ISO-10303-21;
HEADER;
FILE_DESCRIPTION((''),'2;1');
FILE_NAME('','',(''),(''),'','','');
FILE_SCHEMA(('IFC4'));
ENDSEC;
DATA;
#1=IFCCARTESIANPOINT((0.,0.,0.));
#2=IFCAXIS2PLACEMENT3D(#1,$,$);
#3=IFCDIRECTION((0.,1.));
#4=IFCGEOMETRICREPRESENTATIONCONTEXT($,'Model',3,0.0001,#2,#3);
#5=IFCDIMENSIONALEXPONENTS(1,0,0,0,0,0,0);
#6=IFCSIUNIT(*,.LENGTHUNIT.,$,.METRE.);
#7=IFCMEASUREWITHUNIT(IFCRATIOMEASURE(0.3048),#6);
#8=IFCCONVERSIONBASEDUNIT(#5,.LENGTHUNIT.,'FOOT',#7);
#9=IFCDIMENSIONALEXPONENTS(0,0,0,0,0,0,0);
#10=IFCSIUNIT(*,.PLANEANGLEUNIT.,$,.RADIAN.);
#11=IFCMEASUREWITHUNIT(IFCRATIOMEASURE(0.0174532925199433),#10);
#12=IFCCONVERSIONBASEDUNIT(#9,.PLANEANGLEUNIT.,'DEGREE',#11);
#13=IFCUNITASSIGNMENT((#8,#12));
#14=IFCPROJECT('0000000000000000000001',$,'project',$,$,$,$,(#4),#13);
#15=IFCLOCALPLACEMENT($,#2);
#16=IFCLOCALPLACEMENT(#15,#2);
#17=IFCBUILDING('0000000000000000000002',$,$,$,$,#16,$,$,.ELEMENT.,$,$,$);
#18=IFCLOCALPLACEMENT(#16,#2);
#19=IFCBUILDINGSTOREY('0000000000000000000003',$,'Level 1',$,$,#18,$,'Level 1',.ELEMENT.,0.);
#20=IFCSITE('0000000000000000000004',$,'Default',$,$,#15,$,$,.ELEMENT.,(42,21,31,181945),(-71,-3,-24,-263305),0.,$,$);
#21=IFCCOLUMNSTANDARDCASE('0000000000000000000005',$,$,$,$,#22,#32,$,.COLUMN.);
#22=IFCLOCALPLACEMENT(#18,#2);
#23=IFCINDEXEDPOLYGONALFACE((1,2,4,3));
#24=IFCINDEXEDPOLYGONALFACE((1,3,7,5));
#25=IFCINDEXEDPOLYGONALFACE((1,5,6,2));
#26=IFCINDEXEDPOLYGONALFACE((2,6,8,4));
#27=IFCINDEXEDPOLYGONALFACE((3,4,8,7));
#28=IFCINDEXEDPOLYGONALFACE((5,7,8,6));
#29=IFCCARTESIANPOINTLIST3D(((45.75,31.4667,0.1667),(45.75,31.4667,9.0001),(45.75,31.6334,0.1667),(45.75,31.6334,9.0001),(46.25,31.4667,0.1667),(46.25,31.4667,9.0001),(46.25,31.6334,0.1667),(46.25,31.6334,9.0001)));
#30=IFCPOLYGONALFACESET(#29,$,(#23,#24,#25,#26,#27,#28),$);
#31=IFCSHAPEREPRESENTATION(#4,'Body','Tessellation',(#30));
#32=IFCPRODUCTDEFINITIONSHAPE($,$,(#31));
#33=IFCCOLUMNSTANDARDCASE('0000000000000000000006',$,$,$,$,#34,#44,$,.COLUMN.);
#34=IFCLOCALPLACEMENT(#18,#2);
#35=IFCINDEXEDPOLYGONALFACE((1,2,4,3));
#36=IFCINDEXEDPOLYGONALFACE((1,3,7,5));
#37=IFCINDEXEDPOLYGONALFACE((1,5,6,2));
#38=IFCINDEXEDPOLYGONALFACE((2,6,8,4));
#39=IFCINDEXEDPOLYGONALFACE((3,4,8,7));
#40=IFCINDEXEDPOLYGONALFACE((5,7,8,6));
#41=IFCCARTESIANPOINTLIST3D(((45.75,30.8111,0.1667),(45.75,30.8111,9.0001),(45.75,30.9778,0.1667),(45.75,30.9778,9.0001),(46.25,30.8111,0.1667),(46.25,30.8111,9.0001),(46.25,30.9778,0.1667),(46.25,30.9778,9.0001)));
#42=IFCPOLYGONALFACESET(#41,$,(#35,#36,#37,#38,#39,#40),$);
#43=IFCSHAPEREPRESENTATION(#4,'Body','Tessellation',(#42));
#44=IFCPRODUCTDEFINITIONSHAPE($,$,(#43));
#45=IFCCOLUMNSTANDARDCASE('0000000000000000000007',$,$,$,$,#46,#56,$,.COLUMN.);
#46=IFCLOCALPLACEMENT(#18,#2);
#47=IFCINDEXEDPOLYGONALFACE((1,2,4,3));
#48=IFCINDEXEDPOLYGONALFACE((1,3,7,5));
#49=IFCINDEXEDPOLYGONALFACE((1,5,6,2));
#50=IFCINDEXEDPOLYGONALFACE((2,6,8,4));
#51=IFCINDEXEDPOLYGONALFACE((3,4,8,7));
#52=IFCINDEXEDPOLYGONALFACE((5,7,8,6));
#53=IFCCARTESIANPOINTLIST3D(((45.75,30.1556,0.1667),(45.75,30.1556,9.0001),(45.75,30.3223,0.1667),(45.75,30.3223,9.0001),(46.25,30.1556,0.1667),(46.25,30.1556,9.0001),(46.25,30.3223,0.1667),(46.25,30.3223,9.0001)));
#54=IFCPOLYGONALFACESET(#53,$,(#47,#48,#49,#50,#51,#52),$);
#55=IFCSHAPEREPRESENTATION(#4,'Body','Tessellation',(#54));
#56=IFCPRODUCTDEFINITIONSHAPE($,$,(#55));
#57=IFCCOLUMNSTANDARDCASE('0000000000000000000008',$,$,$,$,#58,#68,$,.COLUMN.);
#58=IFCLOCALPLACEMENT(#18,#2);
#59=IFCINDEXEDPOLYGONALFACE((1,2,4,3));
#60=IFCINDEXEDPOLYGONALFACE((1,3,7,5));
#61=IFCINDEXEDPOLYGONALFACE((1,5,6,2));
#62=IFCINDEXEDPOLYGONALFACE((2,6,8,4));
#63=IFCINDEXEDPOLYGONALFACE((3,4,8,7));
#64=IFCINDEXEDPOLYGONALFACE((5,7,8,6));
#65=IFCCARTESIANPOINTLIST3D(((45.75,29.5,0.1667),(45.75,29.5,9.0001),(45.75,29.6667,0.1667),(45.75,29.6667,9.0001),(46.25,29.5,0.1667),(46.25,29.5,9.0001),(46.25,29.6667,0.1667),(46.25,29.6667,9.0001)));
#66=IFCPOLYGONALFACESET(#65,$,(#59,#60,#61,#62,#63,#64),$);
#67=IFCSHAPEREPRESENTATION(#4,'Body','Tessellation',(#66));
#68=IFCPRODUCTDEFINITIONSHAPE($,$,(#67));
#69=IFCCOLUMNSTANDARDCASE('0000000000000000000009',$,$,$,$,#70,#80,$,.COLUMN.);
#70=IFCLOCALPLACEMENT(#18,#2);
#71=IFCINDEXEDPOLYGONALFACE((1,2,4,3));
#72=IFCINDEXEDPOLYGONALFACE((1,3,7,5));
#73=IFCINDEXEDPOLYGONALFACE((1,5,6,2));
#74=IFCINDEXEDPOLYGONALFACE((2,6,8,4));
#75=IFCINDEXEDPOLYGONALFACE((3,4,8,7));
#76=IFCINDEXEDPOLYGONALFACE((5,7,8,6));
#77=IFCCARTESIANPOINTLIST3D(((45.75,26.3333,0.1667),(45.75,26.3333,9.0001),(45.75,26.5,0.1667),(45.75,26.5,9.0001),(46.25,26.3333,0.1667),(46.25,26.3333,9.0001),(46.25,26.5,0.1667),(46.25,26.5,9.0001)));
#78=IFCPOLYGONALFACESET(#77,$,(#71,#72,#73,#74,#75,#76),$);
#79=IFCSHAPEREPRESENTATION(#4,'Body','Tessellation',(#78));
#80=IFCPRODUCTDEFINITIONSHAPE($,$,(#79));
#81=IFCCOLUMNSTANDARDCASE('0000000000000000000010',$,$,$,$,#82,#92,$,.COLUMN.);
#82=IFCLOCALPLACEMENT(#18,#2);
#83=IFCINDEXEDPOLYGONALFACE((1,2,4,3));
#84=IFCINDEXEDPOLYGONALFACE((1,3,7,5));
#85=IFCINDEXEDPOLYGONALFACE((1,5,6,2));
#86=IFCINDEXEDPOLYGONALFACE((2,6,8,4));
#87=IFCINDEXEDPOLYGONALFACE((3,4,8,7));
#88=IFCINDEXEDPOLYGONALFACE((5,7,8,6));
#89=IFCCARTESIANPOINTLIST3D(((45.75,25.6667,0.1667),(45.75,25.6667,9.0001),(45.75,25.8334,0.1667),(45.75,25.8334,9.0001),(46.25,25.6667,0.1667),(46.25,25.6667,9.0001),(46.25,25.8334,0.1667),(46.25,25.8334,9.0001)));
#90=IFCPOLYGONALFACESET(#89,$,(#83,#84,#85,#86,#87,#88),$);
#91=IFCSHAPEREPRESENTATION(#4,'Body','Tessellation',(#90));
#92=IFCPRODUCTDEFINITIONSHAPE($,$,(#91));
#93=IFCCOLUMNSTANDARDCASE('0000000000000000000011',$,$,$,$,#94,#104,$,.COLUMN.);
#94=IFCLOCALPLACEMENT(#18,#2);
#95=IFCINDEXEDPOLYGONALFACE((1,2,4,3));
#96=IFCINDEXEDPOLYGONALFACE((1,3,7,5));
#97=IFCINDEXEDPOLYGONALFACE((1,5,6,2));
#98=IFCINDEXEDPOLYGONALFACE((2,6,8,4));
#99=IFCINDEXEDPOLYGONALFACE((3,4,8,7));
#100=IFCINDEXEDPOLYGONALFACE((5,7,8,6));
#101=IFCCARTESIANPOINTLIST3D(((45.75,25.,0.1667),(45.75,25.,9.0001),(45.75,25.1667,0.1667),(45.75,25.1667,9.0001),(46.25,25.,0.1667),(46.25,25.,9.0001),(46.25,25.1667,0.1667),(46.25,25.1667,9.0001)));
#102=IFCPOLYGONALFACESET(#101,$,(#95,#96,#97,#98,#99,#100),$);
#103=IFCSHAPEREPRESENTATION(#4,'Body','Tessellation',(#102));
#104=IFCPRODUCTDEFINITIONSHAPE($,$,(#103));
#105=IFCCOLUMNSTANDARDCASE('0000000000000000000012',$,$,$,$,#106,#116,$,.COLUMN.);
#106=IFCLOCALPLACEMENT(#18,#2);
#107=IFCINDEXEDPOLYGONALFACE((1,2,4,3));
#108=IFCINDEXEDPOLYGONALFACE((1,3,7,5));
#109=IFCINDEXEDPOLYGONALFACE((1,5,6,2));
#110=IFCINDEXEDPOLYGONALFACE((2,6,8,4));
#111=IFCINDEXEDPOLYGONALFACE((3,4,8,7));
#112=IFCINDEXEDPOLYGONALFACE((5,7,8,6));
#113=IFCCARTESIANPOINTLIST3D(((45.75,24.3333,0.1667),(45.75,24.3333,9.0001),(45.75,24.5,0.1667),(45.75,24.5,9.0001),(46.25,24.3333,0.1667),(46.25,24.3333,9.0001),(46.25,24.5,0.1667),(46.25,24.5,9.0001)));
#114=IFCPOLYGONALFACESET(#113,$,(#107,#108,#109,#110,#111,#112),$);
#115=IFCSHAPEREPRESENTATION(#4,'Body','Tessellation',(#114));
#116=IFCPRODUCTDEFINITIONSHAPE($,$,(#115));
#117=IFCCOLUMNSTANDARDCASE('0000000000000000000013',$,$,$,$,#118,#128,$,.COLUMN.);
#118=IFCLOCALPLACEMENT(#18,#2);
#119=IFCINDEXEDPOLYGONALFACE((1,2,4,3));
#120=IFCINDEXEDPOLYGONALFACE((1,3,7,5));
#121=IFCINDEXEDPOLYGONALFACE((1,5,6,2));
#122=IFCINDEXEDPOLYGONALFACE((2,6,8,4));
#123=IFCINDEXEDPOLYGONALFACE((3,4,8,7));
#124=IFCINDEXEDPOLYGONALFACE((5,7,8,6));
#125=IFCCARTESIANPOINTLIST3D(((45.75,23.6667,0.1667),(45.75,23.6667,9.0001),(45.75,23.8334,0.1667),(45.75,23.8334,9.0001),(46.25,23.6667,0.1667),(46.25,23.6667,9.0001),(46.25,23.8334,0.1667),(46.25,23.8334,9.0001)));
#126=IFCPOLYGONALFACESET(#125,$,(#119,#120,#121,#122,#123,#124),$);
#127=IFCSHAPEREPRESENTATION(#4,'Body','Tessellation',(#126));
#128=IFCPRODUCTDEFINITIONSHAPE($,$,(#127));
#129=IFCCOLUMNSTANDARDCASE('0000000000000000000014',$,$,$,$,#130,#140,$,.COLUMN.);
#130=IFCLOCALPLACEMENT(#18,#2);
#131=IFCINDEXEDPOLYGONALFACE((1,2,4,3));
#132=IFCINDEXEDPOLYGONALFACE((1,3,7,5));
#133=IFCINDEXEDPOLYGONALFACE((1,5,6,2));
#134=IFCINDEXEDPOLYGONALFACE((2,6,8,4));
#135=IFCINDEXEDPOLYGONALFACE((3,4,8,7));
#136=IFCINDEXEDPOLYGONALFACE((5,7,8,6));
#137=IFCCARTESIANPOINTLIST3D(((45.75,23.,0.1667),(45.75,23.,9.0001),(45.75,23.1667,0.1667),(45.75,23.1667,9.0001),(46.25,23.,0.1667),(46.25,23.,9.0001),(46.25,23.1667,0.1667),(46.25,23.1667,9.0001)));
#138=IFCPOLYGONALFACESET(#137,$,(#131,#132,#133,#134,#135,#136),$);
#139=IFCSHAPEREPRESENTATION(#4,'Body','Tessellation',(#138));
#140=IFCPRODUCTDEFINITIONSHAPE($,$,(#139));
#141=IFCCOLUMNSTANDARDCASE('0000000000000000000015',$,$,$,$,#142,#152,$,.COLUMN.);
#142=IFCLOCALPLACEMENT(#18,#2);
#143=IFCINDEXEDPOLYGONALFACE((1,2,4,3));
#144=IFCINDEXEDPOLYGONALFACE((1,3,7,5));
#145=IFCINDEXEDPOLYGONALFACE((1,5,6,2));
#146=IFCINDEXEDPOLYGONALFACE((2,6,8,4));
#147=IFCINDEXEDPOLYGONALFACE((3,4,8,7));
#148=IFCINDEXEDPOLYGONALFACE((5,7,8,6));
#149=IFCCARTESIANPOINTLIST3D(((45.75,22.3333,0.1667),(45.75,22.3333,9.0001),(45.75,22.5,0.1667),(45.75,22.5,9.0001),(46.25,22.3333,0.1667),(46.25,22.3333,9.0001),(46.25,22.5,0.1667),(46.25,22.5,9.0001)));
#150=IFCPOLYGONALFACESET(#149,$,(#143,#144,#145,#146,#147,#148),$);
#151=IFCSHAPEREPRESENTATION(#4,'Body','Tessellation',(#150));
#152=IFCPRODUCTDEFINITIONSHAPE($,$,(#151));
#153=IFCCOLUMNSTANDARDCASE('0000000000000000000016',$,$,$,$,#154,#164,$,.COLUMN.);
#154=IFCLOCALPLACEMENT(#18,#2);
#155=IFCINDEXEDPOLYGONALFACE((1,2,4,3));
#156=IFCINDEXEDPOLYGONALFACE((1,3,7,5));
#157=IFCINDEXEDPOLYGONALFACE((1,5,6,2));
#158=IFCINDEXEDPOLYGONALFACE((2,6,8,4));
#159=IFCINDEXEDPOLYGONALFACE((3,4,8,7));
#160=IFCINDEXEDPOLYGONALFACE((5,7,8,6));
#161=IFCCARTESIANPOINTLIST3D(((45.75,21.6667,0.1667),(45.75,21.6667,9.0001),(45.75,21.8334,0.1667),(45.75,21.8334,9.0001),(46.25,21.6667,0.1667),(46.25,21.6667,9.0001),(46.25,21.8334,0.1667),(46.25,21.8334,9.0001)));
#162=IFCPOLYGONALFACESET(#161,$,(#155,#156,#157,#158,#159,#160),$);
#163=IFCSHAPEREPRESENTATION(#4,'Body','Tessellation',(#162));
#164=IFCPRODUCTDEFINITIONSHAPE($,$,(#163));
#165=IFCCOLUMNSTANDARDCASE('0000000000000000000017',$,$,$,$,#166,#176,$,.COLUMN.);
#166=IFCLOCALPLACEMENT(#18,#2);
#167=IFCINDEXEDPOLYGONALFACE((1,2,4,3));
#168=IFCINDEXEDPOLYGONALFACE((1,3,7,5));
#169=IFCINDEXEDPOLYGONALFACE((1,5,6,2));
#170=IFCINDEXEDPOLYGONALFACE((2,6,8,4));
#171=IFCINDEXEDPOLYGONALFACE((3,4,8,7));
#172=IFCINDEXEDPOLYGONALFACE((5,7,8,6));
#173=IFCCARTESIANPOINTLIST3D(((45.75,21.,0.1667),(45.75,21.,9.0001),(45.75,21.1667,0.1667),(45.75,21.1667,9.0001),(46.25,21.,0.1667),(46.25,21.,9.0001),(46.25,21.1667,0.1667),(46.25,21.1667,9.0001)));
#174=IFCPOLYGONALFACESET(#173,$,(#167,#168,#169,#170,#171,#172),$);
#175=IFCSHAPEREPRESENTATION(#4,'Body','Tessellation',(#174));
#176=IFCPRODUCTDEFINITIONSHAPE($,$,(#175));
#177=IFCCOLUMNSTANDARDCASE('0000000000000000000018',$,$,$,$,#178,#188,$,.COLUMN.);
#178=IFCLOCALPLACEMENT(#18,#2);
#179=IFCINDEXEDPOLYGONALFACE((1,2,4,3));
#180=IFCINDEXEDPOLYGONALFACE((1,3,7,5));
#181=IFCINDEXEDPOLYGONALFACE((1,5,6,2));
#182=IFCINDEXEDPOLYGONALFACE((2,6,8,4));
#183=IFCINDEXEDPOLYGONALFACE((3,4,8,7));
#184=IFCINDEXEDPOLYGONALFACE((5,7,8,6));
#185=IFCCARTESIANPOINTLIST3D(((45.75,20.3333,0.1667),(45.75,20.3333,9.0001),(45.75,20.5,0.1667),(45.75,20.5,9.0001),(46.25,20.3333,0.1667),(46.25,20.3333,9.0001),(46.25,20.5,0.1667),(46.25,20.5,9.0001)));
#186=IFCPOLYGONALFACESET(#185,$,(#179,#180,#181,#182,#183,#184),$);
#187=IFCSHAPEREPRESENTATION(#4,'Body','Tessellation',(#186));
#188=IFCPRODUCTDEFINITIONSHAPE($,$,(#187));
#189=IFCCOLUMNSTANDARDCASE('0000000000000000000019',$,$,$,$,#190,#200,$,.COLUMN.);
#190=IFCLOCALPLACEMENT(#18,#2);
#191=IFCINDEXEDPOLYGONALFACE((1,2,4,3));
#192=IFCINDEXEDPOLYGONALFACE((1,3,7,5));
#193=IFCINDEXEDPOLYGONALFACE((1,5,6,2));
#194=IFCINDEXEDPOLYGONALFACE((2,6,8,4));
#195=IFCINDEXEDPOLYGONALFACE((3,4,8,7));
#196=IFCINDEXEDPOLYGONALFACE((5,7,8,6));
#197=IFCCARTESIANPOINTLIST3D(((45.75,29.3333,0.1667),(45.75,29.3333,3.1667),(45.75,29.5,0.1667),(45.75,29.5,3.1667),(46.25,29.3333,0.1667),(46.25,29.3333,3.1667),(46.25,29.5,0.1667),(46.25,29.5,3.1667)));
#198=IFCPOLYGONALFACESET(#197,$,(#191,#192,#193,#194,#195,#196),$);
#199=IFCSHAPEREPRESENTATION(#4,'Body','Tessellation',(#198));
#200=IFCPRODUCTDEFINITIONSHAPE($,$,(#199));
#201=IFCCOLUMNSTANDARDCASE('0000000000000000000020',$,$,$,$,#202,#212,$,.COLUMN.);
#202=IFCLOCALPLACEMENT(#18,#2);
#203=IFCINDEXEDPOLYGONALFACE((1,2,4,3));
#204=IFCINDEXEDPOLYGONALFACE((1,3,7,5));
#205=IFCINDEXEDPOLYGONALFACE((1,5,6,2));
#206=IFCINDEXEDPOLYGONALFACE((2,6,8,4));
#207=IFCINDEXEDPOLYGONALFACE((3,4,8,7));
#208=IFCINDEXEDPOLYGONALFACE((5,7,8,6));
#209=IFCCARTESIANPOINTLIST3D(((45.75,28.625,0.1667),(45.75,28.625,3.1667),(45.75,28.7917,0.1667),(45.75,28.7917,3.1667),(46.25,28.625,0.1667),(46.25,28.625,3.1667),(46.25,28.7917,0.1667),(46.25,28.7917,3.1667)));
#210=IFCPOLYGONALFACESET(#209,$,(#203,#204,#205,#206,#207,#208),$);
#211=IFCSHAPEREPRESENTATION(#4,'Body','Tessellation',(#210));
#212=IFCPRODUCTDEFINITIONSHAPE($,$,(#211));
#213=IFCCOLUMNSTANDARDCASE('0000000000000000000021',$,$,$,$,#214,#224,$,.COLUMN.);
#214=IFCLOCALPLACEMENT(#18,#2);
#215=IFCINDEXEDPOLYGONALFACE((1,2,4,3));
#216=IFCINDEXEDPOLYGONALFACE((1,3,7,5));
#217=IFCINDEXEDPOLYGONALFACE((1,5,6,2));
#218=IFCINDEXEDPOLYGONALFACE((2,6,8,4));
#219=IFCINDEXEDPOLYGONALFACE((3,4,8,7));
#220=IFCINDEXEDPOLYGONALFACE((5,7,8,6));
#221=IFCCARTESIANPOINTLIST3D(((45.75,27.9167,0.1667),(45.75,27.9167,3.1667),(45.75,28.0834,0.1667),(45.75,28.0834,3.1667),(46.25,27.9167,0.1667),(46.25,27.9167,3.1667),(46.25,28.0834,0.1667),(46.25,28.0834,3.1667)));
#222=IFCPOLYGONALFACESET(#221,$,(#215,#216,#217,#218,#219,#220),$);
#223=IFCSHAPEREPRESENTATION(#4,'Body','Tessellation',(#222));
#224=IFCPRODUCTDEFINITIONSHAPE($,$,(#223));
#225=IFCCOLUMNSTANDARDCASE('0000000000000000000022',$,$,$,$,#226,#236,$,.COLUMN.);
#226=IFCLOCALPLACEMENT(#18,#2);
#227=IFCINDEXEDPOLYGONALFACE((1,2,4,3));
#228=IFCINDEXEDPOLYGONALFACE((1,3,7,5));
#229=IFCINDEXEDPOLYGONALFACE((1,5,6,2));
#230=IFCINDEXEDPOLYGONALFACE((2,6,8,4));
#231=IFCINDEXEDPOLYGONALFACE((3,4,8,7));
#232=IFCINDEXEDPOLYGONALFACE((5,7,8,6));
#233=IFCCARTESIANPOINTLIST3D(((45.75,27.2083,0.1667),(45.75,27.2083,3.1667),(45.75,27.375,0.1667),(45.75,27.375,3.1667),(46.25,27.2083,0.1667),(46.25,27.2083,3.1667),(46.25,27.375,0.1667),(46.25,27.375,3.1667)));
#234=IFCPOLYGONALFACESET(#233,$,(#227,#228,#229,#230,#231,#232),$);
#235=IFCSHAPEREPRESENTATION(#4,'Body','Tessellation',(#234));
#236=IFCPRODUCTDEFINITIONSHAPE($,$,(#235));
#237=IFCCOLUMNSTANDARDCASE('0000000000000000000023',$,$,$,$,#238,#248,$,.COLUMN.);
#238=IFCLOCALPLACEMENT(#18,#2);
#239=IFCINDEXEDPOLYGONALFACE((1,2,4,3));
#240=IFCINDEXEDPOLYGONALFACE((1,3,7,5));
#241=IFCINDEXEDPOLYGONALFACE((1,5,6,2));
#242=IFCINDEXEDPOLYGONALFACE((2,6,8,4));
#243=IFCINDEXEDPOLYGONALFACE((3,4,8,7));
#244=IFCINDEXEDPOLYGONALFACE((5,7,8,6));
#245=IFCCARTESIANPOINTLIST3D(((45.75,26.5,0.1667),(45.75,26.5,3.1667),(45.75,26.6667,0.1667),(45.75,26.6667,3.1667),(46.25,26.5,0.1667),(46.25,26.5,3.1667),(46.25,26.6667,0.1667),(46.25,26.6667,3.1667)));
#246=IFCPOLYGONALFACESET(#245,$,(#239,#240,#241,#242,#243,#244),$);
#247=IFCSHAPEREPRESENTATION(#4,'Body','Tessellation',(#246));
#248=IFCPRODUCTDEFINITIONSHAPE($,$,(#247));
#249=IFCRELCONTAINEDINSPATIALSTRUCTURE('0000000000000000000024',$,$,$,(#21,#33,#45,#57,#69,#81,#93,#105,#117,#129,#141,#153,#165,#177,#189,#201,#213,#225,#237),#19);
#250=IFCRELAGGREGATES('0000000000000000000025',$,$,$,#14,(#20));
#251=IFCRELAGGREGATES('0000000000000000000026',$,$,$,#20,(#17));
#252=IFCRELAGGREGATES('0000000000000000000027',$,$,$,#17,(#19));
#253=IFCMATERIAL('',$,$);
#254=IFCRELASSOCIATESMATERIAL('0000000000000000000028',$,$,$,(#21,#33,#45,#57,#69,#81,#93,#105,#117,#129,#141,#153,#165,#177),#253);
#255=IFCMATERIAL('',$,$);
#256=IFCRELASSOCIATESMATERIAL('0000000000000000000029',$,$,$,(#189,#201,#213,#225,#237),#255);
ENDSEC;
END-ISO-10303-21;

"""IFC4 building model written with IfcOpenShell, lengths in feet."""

from ifc_helpers import new_model, entity, si_unit, converted_unit, direction, frame, origin, place, context, project, spatial, rectangle, extrude, material, element, save


model = new_model("IFC4")

# Units and contexts
model_context = context("Model", 3, precision=0.0001, world=origin(), true_north=direction((0.0, 1.0)))
ifc_project = project(units=[converted_unit("LENGTHUNIT", "FOOT", entity("IfcRatioMeasure", 0.3048), si_unit("LENGTHUNIT", "METRE"), dimensions=[1, 0, 0, 0, 0, 0, 0]), converted_unit("PLANEANGLEUNIT", "DEGREE", entity("IfcRatioMeasure", 0.0174532925199433), si_unit("PLANEANGLEUNIT", "RADIAN"), dimensions=[0, 0, 0, 0, 0, 0, 0])], contexts=[model_context])

# Site, building, storey
site_placement = place(None, origin())
site = spatial("IfcSite", under=ifc_project, at=site_placement, Name="Default", CompositionType="ELEMENT", RefLatitude=(42, 21, 31, 181945), RefLongitude=(-71, -3, -24, -263305), RefElevation=0.0)
building_placement = place(site_placement, origin())
building = spatial("IfcBuilding", under=site, at=building_placement, CompositionType="ELEMENT")
storey_placement = place(building_placement, origin())
storey = spatial("IfcBuildingStorey", under=building, at=storey_placement, Name="Level 1", LongName="Level 1", CompositionType="ELEMENT", Elevation=0.0)

# Columns
ifc_material_1 = material(Name="")
placement_1 = place(storey_placement, frame((46.0, 46.25, 0.0), z_axis=(0.0, 0.0, 1.0), x_axis=(0.0, -1.0, 0.0)))
for number, where, z_axis, x_axis in (
    (1, (14.7, 0.0, 0.1667), (0.0, 0.0, 1.0), (1.0, 0.0, 0.0)),
    (2, (15.3556, 0.0, 0.1667), (0.0, 0.0, 1.0), (1.0, 0.0, 0.0)),
    (3, (16.0111, 0.0, 0.1667), (0.0, 0.0, 1.0), (1.0, 0.0, 0.0)),
    (4, (16.6667, 0.0, 0.1667), (0.0, 0.0, 1.0), (1.0, 0.0, 0.0)),
    (5, (19.8334, 0.0, 0.1667), (0.0, 0.0, 1.0), (1.0, 0.0, 0.0)),
    (6, (20.5, 0.0, 0.1667), (0.0, 0.0, 1.0), (1.0, 0.0, 0.0)),
    (7, (21.1667, 0.0, 0.1667), (0.0, 0.0, 1.0), (1.0, 0.0, 0.0)),
    (8, (21.8334, 0.0, 0.1667), (0.0, 0.0, 1.0), (1.0, 0.0, 0.0)),
    (9, (22.5, 0.0, 0.1667), (0.0, 0.0, 1.0), (1.0, 0.0, 0.0)),
    (10, (23.1667, 0.0, 0.1667), (0.0, 0.0, 1.0), (1.0, 0.0, 0.0)),
    (11, (23.8334, 0.0, 0.1667), (0.0, 0.0, 1.0), (1.0, 0.0, 0.0)),
    (12, (24.5, 0.0, 0.1667), (0.0, 0.0, 1.0), (1.0, 0.0, 0.0)),
    (13, (25.1667, 0.0, 0.1667), (0.0, 0.0, 1.0), (1.0, 0.0, 0.0)),
    (14, (25.8334, 0.0, 0.1667), (0.0, 0.0, 1.0), (1.0, 0.0, 0.0)),
):
    element("IfcColumnStandardCase", number, at=place(placement_1, frame(where, z_axis=z_axis, x_axis=x_axis)), inside=storey, material=ifc_material_1, PredefinedType="COLUMN", context=model_context, shape_type="SweptSolid", body=[
        extrude(rectangle(XDim=0.1667, YDim=0.5), origin(), (0.0, 0.0, 1.0), 8.8334),
    ])
ifc_material_2 = material(Name="")
for number, where, z_axis, x_axis in (
    (15, (16.8334, 0.0, 0.1667), (0.0, 0.0, 1.0), (1.0, 0.0, 0.0)),
    (16, (17.5417, 0.0, 0.1667), (0.0, 0.0, 1.0), (1.0, 0.0, 0.0)),
    (17, (18.25, 0.0, 0.1667), (0.0, 0.0, 1.0), (1.0, 0.0, 0.0)),
    (18, (18.9584, 0.0, 0.1667), (0.0, 0.0, 1.0), (1.0, 0.0, 0.0)),
    (19, (19.6667, 0.0, 0.1667), (0.0, 0.0, 1.0), (1.0, 0.0, 0.0)),
):
    element("IfcColumnStandardCase", number, at=place(placement_1, frame(where, z_axis=z_axis, x_axis=x_axis)), inside=storey, material=ifc_material_2, PredefinedType="COLUMN", context=model_context, shape_type="SweptSolid", body=[
        extrude(rectangle(XDim=0.1667, YDim=0.5), origin(), (0.0, 0.0, 1.0), 3.0),
    ])

save(model, "model.ifc")
